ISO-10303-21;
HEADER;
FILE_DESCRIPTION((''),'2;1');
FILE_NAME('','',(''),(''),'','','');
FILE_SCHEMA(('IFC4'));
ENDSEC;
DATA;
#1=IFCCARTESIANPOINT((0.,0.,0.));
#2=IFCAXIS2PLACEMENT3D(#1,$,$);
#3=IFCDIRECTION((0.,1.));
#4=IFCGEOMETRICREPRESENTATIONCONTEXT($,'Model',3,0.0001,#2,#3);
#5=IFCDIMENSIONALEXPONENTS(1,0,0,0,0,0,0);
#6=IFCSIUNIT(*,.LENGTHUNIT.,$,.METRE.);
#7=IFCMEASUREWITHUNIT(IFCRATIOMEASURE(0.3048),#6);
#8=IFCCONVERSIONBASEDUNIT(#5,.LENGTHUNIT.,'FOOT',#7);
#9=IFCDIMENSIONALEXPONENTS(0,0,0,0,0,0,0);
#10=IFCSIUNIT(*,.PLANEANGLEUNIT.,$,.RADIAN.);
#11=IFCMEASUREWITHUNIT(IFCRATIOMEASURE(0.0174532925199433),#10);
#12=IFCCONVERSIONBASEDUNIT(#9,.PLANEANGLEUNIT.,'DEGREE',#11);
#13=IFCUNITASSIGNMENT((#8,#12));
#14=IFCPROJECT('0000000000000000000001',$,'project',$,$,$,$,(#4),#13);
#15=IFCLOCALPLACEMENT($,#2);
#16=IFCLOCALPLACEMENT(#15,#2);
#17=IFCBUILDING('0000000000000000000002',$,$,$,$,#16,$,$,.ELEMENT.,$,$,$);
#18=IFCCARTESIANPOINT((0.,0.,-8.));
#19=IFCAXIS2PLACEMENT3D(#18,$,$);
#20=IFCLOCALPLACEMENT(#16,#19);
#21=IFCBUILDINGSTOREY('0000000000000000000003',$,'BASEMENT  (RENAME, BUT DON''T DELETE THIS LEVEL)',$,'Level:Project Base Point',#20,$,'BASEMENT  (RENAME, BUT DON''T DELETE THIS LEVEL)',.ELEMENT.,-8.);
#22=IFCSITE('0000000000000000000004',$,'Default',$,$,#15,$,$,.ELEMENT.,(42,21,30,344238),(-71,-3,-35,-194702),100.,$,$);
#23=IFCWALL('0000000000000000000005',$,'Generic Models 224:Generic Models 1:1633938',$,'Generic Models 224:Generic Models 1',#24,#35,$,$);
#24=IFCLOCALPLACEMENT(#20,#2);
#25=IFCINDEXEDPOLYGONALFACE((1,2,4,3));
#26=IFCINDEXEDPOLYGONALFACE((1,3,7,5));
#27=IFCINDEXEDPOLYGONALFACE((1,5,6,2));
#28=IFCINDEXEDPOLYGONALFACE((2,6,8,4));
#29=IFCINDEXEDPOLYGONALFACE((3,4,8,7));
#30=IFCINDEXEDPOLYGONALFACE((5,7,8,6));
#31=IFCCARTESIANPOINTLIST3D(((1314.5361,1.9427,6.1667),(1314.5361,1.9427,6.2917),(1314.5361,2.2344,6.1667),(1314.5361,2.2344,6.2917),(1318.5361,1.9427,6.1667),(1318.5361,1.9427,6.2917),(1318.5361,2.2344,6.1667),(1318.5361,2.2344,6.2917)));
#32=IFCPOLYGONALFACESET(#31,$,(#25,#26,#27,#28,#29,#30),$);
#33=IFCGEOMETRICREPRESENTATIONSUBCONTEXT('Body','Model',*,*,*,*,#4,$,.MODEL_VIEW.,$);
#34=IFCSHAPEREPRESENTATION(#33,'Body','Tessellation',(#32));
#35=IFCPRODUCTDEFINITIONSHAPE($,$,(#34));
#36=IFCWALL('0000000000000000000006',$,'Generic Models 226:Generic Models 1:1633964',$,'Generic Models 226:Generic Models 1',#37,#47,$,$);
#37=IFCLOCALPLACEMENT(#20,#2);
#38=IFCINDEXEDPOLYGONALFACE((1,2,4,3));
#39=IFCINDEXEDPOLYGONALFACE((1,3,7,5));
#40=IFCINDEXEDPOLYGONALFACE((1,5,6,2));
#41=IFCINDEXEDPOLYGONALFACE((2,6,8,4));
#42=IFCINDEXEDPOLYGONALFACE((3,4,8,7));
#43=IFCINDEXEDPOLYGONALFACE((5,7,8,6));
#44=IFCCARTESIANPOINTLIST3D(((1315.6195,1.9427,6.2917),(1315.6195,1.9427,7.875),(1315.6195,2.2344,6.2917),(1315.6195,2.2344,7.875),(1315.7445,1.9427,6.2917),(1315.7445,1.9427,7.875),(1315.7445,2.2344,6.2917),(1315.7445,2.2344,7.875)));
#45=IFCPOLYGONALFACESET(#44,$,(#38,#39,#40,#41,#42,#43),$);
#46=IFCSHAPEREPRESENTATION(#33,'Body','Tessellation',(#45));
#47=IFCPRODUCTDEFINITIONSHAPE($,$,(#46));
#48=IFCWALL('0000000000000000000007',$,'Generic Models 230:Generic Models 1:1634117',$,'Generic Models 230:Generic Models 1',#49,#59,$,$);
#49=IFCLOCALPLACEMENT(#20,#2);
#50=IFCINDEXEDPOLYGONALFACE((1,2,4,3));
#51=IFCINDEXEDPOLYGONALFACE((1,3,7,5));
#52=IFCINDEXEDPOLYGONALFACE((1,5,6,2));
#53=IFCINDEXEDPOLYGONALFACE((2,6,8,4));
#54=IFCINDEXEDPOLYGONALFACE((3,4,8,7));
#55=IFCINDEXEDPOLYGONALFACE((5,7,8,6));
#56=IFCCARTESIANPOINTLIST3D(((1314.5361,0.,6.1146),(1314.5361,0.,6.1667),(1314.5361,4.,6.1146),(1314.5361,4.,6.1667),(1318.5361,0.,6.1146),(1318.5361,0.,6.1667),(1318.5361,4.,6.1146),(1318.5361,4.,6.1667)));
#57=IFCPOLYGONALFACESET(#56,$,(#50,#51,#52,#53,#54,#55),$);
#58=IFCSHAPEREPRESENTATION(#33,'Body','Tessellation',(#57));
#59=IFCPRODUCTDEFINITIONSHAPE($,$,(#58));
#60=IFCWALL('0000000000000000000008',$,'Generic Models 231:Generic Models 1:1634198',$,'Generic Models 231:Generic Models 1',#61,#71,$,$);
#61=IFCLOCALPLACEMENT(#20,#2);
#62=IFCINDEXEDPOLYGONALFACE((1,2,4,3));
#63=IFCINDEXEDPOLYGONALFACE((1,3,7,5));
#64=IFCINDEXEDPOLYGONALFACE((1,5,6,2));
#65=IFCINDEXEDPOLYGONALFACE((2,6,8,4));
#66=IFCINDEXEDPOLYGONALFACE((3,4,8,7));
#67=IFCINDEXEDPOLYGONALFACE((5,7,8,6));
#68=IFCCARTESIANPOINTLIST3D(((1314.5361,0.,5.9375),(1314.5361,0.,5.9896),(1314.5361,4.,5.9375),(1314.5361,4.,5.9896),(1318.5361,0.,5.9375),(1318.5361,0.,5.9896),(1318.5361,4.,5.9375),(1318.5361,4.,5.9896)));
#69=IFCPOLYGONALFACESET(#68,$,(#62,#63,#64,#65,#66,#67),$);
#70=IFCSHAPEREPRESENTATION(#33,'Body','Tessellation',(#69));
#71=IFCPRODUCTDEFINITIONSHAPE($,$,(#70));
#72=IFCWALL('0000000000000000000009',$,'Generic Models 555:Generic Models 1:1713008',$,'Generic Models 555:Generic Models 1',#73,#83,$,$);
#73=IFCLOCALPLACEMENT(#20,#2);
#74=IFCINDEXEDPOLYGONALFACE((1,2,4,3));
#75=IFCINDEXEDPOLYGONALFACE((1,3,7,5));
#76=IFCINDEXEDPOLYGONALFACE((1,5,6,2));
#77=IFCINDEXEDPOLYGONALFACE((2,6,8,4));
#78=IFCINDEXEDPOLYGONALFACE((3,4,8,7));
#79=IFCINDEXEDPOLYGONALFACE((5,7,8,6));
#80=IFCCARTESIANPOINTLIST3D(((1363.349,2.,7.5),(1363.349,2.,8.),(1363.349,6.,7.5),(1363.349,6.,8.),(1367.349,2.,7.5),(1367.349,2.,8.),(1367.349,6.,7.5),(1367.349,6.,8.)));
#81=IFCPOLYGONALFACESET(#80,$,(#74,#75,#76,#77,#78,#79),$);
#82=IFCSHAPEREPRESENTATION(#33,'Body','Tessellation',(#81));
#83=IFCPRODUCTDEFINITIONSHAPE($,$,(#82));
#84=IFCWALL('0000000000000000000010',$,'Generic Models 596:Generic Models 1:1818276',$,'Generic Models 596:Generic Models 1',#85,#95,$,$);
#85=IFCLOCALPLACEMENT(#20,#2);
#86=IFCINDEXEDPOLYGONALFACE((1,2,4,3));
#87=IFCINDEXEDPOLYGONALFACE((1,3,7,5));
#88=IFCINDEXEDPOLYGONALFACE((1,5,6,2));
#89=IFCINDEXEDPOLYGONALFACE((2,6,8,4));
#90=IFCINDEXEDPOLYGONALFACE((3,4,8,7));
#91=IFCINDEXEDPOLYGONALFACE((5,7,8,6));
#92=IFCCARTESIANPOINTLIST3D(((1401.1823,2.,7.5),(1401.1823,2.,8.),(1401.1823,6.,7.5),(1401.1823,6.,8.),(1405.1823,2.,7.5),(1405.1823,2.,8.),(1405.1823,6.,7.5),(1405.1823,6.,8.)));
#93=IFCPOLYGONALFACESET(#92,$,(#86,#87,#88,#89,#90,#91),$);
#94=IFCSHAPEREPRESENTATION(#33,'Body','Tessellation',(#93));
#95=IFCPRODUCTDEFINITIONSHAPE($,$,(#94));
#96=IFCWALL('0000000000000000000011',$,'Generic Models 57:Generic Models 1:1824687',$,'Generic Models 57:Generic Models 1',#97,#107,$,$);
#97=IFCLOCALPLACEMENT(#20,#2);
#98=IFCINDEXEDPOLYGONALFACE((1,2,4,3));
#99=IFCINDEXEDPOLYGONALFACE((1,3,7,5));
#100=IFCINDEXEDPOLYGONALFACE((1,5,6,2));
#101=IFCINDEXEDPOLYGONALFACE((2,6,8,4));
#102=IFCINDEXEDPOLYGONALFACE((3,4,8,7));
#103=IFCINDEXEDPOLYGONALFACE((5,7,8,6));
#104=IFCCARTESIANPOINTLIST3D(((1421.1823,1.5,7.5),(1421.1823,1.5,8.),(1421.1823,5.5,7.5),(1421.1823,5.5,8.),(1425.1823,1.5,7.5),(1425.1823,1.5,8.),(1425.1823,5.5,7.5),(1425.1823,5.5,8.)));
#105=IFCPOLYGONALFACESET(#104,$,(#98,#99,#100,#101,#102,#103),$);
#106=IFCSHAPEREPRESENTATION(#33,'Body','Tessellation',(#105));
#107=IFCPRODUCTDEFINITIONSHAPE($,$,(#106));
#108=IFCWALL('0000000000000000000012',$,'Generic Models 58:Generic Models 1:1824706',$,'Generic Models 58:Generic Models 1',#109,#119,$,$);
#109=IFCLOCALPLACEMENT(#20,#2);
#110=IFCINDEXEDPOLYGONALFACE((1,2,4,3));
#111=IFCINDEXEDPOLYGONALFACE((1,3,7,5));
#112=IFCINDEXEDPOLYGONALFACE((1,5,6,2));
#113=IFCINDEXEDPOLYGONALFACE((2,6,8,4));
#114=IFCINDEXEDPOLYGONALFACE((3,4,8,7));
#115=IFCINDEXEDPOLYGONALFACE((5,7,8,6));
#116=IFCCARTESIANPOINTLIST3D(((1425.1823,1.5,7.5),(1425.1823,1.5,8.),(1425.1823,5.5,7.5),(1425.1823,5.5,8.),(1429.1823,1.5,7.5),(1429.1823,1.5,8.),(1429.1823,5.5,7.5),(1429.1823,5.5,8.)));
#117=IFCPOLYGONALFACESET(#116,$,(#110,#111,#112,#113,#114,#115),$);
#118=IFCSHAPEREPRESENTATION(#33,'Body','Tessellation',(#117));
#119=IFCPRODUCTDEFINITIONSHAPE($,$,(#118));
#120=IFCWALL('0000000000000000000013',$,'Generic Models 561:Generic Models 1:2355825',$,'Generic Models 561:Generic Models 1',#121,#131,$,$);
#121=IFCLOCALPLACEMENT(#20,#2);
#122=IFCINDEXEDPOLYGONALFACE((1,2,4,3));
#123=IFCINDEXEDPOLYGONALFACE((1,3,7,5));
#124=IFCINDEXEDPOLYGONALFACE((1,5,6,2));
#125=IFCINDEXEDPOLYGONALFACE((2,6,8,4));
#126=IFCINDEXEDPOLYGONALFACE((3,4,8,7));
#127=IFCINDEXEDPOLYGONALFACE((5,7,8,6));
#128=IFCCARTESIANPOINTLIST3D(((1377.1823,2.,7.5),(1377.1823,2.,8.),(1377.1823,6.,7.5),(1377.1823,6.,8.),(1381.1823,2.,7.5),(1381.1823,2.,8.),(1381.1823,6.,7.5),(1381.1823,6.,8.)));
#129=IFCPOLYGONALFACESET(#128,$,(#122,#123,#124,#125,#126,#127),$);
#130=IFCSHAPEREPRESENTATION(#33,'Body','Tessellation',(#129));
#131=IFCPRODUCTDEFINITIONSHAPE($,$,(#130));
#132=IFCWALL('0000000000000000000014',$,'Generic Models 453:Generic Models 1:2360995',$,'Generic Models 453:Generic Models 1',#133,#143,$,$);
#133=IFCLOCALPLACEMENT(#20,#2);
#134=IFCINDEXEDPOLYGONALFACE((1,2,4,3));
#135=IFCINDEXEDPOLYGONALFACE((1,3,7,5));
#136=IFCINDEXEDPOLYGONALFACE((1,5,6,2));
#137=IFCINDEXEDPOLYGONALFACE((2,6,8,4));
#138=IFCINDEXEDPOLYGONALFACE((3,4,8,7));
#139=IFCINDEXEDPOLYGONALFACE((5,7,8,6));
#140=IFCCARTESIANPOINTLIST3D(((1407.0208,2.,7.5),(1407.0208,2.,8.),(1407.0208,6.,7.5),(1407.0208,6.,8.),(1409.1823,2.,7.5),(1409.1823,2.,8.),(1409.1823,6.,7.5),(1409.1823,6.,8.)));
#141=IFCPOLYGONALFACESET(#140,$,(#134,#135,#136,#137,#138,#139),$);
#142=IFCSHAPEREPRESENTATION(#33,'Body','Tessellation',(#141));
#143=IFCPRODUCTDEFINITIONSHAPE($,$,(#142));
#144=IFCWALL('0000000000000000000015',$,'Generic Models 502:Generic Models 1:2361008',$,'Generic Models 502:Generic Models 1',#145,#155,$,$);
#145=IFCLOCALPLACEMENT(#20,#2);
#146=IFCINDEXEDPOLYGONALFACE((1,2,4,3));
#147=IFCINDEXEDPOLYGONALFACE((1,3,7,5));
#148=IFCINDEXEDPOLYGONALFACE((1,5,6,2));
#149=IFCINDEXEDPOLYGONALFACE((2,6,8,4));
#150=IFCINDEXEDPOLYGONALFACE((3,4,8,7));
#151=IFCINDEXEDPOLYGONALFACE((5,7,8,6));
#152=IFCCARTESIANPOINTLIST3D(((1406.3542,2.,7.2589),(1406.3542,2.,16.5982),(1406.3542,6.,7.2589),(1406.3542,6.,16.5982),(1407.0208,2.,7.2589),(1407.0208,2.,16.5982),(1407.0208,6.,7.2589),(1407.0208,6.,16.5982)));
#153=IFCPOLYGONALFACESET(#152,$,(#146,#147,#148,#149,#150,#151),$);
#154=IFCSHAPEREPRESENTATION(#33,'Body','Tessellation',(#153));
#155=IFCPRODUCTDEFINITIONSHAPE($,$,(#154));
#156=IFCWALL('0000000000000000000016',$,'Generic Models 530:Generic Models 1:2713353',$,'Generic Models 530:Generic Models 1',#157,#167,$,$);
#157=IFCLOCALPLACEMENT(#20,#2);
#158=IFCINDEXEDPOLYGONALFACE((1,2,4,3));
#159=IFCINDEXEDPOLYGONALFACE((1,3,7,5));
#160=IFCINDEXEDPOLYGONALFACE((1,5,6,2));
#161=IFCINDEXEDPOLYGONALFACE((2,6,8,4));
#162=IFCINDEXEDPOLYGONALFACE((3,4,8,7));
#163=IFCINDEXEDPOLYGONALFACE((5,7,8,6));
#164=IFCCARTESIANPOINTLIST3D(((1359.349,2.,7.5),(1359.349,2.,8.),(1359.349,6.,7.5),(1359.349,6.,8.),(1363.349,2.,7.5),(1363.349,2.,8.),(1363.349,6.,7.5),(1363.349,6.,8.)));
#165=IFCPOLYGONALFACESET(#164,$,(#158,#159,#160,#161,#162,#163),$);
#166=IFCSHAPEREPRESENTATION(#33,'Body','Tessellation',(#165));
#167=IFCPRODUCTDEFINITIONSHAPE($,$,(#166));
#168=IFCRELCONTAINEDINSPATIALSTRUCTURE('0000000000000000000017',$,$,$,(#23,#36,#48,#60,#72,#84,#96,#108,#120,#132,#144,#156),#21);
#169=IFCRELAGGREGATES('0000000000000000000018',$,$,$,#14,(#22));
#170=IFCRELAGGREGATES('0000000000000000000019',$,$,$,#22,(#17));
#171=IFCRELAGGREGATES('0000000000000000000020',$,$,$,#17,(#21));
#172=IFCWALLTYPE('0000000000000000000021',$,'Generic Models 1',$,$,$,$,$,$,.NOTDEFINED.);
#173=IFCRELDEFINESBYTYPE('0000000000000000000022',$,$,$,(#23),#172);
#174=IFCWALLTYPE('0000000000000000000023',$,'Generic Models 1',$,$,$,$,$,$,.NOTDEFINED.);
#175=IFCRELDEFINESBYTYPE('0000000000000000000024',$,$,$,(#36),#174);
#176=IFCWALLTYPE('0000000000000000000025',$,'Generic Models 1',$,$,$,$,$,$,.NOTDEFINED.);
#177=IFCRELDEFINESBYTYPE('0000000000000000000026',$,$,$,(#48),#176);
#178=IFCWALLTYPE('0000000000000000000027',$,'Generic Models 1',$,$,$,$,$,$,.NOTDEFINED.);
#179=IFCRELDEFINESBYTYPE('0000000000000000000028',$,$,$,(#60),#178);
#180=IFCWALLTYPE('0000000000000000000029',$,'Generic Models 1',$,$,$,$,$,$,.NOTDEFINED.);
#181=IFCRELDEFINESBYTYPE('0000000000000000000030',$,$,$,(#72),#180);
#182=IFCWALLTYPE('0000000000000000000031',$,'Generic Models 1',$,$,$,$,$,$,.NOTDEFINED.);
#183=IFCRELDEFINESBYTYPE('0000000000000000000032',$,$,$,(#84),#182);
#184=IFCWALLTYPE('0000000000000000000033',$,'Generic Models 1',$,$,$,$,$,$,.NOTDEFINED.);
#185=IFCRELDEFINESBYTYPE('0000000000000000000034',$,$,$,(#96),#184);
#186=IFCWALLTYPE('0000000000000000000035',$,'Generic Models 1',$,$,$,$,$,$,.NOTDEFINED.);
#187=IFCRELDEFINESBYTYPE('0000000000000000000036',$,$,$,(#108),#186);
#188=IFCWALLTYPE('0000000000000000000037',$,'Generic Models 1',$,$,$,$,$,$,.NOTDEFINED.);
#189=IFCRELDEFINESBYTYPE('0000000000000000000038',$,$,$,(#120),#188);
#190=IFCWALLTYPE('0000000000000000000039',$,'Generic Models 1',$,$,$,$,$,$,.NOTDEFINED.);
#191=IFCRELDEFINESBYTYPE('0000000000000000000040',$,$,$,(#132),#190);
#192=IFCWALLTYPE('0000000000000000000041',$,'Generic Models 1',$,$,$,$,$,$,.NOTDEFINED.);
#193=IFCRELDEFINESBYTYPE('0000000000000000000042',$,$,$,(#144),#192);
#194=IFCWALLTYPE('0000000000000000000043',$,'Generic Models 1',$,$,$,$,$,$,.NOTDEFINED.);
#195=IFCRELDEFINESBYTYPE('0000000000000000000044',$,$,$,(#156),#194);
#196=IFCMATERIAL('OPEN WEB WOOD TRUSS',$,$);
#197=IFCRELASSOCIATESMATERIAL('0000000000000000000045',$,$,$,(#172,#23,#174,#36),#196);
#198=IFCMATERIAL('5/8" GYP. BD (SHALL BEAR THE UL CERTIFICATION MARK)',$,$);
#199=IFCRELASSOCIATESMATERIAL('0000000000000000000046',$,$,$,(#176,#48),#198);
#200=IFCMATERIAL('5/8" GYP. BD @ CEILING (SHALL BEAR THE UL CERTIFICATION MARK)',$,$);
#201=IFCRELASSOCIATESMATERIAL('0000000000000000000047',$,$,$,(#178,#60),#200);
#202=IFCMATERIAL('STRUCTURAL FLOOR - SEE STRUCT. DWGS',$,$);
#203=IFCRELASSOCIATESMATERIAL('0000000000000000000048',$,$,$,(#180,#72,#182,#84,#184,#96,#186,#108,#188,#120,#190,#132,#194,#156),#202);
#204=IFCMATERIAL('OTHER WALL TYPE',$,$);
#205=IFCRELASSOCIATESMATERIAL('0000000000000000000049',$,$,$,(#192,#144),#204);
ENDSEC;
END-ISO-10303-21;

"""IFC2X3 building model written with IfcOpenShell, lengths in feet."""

from ifc_helpers import new_model, entity, si_unit, converted_unit, direction, frame, frame_2d, origin, origin_2d_with_axis, place, context, subcontext, project, spatial, rectangle, extrude, material, type_object, element, save


model = new_model("IFC2X3")

# Units and contexts
model_context = context("Model", 3, precision=0.0001, world=origin(), true_north=direction((0.0, 1.0)))
body_context = subcontext(model_context, "Body", "Model", "MODEL_VIEW")
ifc_project = project(units=[converted_unit("LENGTHUNIT", "FOOT", entity("IfcRatioMeasure", 0.3048), si_unit("LENGTHUNIT", "METRE"), dimensions=[1, 0, 0, 0, 0, 0, 0]), converted_unit("PLANEANGLEUNIT", "DEGREE", entity("IfcRatioMeasure", 0.0174532925199433), si_unit("PLANEANGLEUNIT", "RADIAN"), dimensions=[0, 0, 0, 0, 0, 0, 0])], contexts=[model_context])

# Site, building, storey
site_placement = place(None, origin())
site = spatial("IfcSite", under=ifc_project, at=site_placement, Name="Default", CompositionType="ELEMENT", RefLatitude=(42, 21, 30, 344238), RefLongitude=(-71, -3, -35, -194702), RefElevation=100.0)
building_placement = place(site_placement, origin())
building = spatial("IfcBuilding", under=site, at=building_placement, CompositionType="ELEMENT")
storey_placement = place(building_placement, frame((0.0, 0.0, -8.0)))
storey = spatial("IfcBuildingStorey", under=building, at=storey_placement, Name="BASEMENT  (RENAME, BUT DON'T DELETE THIS LEVEL)", ObjectType="Level:Project Base Point", LongName="BASEMENT  (RENAME, BUT DON'T DELETE THIS LEVEL)", CompositionType="ELEMENT", Elevation=-8.0)

# Walls
ifc_material_1 = material(Name="STRUCTURAL FLOOR - SEE STRUCT. DWGS")
ifc_material_2 = material(Name="OTHER WALL TYPE")
ifc_material_3 = material(Name="OPEN WEB WOOD TRUSS")
wall_type_1 = type_object("IfcWallType", Name="Generic Models 1", PredefinedType="NOTDEFINED", material=ifc_material_3)
wall_1_placement = place(storey_placement, frame((1314.5361, 1.9427, 6.1667)))
element("IfcWall", 1, at=wall_1_placement, inside=storey, type_object=wall_type_1, material=ifc_material_3, Name="Generic Models 224:Generic Models 1:1633938", ObjectType="Generic Models 224:Generic Models 1", context=body_context, shape_type="SweptSolid", body=[
    extrude(rectangle(XDim=0.2917, YDim=4.0, at=frame_2d((0.0, 0.0), x_axis=(1.0, 0.0))), frame((2.0, 0.1458, 0.0), z_axis=(0.0, 0.0, 1.0), x_axis=(0.0, 1.0, 0.0)), (0.0, 0.0, 1.0), 0.125),
])
wall_type_2 = type_object("IfcWallType", Name="Generic Models 1", PredefinedType="NOTDEFINED", material=ifc_material_3)
wall_2_placement = place(storey_placement, frame((1315.6195, 1.9427, 6.2917), z_axis=(0.0, 0.0, 1.0), x_axis=(0.0, 1.0, 0.0)))
element("IfcWall", 2, at=wall_2_placement, inside=storey, type_object=wall_type_2, material=ifc_material_3, Name="Generic Models 226:Generic Models 1:1633964", ObjectType="Generic Models 226:Generic Models 1", context=body_context, shape_type="SweptSolid", body=[
    extrude(rectangle(XDim=0.2917, YDim=0.125, at=frame_2d((0.0, 0.0), x_axis=(1.0, 0.0))), frame((0.1458, -0.0625, 0.0)), (0.0, 0.0, 1.0), 1.5833),
])
ifc_material_4 = material(Name="5/8\" GYP. BD (SHALL BEAR THE UL CERTIFICATION MARK)")
wall_type_3 = type_object("IfcWallType", Name="Generic Models 1", PredefinedType="NOTDEFINED", material=ifc_material_4)
wall_3_placement = place(storey_placement, frame((1314.5361, 0.0, 6.1146), z_axis=(0.0, 0.0, 1.0), x_axis=(0.0, 1.0, 0.0)))
element("IfcWall", 3, at=wall_3_placement, inside=storey, type_object=wall_type_3, material=ifc_material_4, Name="Generic Models 230:Generic Models 1:1634117", ObjectType="Generic Models 230:Generic Models 1", context=body_context, shape_type="SweptSolid", body=[
    extrude(rectangle(XDim=4.0, YDim=4.0, at=origin_2d_with_axis()), frame((2.0, -2.0, 0.0)), (0.0, 0.0, 1.0), 0.0521),
])
ifc_material_5 = material(Name="5/8\" GYP. BD @ CEILING (SHALL BEAR THE UL CERTIFICATION MARK)")
wall_type_4 = type_object("IfcWallType", Name="Generic Models 1", PredefinedType="NOTDEFINED", material=ifc_material_5)
wall_4_placement = place(storey_placement, frame((1314.5361, 0.0, 5.9375), z_axis=(0.0, 0.0, 1.0), x_axis=(0.0, 1.0, 0.0)))
element("IfcWall", 4, at=wall_4_placement, inside=storey, type_object=wall_type_4, material=ifc_material_5, Name="Generic Models 231:Generic Models 1:1634198", ObjectType="Generic Models 231:Generic Models 1", context=body_context, shape_type="SweptSolid", body=[
    extrude(rectangle(XDim=4.0, YDim=4.0, at=origin_2d_with_axis()), frame((2.0, -2.0, 0.0)), (0.0, 0.0, 1.0), 0.0521),
])
wall_type_5 = type_object("IfcWallType", Name="Generic Models 1", PredefinedType="NOTDEFINED", material=ifc_material_1)
wall_5_placement = place(storey_placement, frame((1363.349, 2.0, 7.5), z_axis=(0.0, 0.0, 1.0), x_axis=(0.0, 1.0, 0.0)))
element("IfcWall", 5, at=wall_5_placement, inside=storey, type_object=wall_type_5, material=ifc_material_1, Name="Generic Models 555:Generic Models 1:1713008", ObjectType="Generic Models 555:Generic Models 1", context=body_context, shape_type="SweptSolid", body=[
    extrude(rectangle(XDim=4.0, YDim=4.0, at=origin_2d_with_axis()), frame((2.0, -2.0, 0.0)), (0.0, 0.0, 1.0), 0.5),
])
wall_type_6 = type_object("IfcWallType", Name="Generic Models 1", PredefinedType="NOTDEFINED", material=ifc_material_1)
wall_6_placement = place(storey_placement, frame((1401.1823, 2.0, 7.5), z_axis=(0.0, 0.0, 1.0), x_axis=(0.0, 1.0, 0.0)))
element("IfcWall", 6, at=wall_6_placement, inside=storey, type_object=wall_type_6, material=ifc_material_1, Name="Generic Models 596:Generic Models 1:1818276", ObjectType="Generic Models 596:Generic Models 1", context=body_context, shape_type="SweptSolid", body=[
    extrude(rectangle(XDim=4.0, YDim=4.0, at=origin_2d_with_axis()), frame((2.0, -2.0, 0.0)), (0.0, 0.0, 1.0), 0.5),
])
wall_type_7 = type_object("IfcWallType", Name="Generic Models 1", PredefinedType="NOTDEFINED", material=ifc_material_1)
wall_7_placement = place(storey_placement, frame((1421.1823, 1.5, 7.5), z_axis=(0.0, 0.0, 1.0), x_axis=(0.0, 1.0, 0.0)))
element("IfcWall", 7, at=wall_7_placement, inside=storey, type_object=wall_type_7, material=ifc_material_1, Name="Generic Models 57:Generic Models 1:1824687", ObjectType="Generic Models 57:Generic Models 1", context=body_context, shape_type="SweptSolid", body=[
    extrude(rectangle(XDim=4.0, YDim=4.0, at=frame_2d((0.0, 0.0), x_axis=(1.0, 0.0))), frame((2.0, -2.0, 0.0)), (0.0, 0.0, 1.0), 0.5),
])
wall_type_8 = type_object("IfcWallType", Name="Generic Models 1", PredefinedType="NOTDEFINED", material=ifc_material_1)
wall_8_placement = place(storey_placement, frame((1425.1823, 1.5, 7.5), z_axis=(0.0, 0.0, 1.0), x_axis=(0.0, 1.0, 0.0)))
element("IfcWall", 8, at=wall_8_placement, inside=storey, type_object=wall_type_8, material=ifc_material_1, Name="Generic Models 58:Generic Models 1:1824706", ObjectType="Generic Models 58:Generic Models 1", context=body_context, shape_type="SweptSolid", body=[
    extrude(rectangle(XDim=4.0, YDim=4.0, at=origin_2d_with_axis()), frame((2.0, -2.0, 0.0)), (0.0, 0.0, 1.0), 0.5),
])
wall_type_9 = type_object("IfcWallType", Name="Generic Models 1", PredefinedType="NOTDEFINED", material=ifc_material_1)
wall_9_placement = place(storey_placement, frame((1377.1823, 2.0, 7.5), z_axis=(0.0, 0.0, 1.0), x_axis=(0.0, 1.0, 0.0)))
element("IfcWall", 9, at=wall_9_placement, inside=storey, type_object=wall_type_9, material=ifc_material_1, Name="Generic Models 561:Generic Models 1:2355825", ObjectType="Generic Models 561:Generic Models 1", context=body_context, shape_type="SweptSolid", body=[
    extrude(rectangle(XDim=4.0, YDim=4.0, at=frame_2d((0.0, 0.0), x_axis=(1.0, 0.0))), frame((2.0, -2.0, 0.0)), (0.0, 0.0, 1.0), 0.5),
])
wall_type_10 = type_object("IfcWallType", Name="Generic Models 1", PredefinedType="NOTDEFINED", material=ifc_material_1)
wall_10_placement = place(storey_placement, frame((1407.0208, 2.0, 7.5), z_axis=(0.0, 0.0, 1.0), x_axis=(0.0, 1.0, 0.0)))
element("IfcWall", 10, at=wall_10_placement, inside=storey, type_object=wall_type_10, material=ifc_material_1, Name="Generic Models 453:Generic Models 1:2360995", ObjectType="Generic Models 453:Generic Models 1", context=body_context, shape_type="SweptSolid", body=[
    extrude(rectangle(XDim=4.0, YDim=2.1615, at=frame_2d((0.0, 0.0), x_axis=(1.0, 0.0))), frame((2.0, -1.0807, 0.0)), (0.0, 0.0, 1.0), 0.5),
])
wall_type_11 = type_object("IfcWallType", Name="Generic Models 1", PredefinedType="NOTDEFINED", material=ifc_material_2)
wall_11_placement = place(storey_placement, frame((1406.3542, 2.0, 7.2589), z_axis=(0.0, 0.0, 1.0), x_axis=(0.0, 1.0, 0.0)))
element("IfcWall", 11, at=wall_11_placement, inside=storey, type_object=wall_type_11, material=ifc_material_2, Name="Generic Models 502:Generic Models 1:2361008", ObjectType="Generic Models 502:Generic Models 1", context=body_context, shape_type="SweptSolid", body=[
    extrude(rectangle(XDim=4.0, YDim=0.6667, at=frame_2d((0.0, 0.0), x_axis=(1.0, 0.0))), frame((2.0, -0.3333, 0.0)), (0.0, 0.0, 1.0), 9.3393),
])
wall_type_12 = type_object("IfcWallType", Name="Generic Models 1", PredefinedType="NOTDEFINED", material=ifc_material_1)
wall_12_placement = place(storey_placement, frame((1359.349, 2.0, 7.5), z_axis=(0.0, 0.0, 1.0), x_axis=(0.0, 1.0, 0.0)))
element("IfcWall", 12, at=wall_12_placement, inside=storey, type_object=wall_type_12, material=ifc_material_1, Name="Generic Models 530:Generic Models 1:2713353", ObjectType="Generic Models 530:Generic Models 1", context=body_context, shape_type="SweptSolid", body=[
    extrude(rectangle(XDim=4.0, YDim=4.0, at=origin_2d_with_axis()), frame((2.0, -2.0, 0.0)), (0.0, 0.0, 1.0), 0.5),
])

save(model, "model.ifc")
